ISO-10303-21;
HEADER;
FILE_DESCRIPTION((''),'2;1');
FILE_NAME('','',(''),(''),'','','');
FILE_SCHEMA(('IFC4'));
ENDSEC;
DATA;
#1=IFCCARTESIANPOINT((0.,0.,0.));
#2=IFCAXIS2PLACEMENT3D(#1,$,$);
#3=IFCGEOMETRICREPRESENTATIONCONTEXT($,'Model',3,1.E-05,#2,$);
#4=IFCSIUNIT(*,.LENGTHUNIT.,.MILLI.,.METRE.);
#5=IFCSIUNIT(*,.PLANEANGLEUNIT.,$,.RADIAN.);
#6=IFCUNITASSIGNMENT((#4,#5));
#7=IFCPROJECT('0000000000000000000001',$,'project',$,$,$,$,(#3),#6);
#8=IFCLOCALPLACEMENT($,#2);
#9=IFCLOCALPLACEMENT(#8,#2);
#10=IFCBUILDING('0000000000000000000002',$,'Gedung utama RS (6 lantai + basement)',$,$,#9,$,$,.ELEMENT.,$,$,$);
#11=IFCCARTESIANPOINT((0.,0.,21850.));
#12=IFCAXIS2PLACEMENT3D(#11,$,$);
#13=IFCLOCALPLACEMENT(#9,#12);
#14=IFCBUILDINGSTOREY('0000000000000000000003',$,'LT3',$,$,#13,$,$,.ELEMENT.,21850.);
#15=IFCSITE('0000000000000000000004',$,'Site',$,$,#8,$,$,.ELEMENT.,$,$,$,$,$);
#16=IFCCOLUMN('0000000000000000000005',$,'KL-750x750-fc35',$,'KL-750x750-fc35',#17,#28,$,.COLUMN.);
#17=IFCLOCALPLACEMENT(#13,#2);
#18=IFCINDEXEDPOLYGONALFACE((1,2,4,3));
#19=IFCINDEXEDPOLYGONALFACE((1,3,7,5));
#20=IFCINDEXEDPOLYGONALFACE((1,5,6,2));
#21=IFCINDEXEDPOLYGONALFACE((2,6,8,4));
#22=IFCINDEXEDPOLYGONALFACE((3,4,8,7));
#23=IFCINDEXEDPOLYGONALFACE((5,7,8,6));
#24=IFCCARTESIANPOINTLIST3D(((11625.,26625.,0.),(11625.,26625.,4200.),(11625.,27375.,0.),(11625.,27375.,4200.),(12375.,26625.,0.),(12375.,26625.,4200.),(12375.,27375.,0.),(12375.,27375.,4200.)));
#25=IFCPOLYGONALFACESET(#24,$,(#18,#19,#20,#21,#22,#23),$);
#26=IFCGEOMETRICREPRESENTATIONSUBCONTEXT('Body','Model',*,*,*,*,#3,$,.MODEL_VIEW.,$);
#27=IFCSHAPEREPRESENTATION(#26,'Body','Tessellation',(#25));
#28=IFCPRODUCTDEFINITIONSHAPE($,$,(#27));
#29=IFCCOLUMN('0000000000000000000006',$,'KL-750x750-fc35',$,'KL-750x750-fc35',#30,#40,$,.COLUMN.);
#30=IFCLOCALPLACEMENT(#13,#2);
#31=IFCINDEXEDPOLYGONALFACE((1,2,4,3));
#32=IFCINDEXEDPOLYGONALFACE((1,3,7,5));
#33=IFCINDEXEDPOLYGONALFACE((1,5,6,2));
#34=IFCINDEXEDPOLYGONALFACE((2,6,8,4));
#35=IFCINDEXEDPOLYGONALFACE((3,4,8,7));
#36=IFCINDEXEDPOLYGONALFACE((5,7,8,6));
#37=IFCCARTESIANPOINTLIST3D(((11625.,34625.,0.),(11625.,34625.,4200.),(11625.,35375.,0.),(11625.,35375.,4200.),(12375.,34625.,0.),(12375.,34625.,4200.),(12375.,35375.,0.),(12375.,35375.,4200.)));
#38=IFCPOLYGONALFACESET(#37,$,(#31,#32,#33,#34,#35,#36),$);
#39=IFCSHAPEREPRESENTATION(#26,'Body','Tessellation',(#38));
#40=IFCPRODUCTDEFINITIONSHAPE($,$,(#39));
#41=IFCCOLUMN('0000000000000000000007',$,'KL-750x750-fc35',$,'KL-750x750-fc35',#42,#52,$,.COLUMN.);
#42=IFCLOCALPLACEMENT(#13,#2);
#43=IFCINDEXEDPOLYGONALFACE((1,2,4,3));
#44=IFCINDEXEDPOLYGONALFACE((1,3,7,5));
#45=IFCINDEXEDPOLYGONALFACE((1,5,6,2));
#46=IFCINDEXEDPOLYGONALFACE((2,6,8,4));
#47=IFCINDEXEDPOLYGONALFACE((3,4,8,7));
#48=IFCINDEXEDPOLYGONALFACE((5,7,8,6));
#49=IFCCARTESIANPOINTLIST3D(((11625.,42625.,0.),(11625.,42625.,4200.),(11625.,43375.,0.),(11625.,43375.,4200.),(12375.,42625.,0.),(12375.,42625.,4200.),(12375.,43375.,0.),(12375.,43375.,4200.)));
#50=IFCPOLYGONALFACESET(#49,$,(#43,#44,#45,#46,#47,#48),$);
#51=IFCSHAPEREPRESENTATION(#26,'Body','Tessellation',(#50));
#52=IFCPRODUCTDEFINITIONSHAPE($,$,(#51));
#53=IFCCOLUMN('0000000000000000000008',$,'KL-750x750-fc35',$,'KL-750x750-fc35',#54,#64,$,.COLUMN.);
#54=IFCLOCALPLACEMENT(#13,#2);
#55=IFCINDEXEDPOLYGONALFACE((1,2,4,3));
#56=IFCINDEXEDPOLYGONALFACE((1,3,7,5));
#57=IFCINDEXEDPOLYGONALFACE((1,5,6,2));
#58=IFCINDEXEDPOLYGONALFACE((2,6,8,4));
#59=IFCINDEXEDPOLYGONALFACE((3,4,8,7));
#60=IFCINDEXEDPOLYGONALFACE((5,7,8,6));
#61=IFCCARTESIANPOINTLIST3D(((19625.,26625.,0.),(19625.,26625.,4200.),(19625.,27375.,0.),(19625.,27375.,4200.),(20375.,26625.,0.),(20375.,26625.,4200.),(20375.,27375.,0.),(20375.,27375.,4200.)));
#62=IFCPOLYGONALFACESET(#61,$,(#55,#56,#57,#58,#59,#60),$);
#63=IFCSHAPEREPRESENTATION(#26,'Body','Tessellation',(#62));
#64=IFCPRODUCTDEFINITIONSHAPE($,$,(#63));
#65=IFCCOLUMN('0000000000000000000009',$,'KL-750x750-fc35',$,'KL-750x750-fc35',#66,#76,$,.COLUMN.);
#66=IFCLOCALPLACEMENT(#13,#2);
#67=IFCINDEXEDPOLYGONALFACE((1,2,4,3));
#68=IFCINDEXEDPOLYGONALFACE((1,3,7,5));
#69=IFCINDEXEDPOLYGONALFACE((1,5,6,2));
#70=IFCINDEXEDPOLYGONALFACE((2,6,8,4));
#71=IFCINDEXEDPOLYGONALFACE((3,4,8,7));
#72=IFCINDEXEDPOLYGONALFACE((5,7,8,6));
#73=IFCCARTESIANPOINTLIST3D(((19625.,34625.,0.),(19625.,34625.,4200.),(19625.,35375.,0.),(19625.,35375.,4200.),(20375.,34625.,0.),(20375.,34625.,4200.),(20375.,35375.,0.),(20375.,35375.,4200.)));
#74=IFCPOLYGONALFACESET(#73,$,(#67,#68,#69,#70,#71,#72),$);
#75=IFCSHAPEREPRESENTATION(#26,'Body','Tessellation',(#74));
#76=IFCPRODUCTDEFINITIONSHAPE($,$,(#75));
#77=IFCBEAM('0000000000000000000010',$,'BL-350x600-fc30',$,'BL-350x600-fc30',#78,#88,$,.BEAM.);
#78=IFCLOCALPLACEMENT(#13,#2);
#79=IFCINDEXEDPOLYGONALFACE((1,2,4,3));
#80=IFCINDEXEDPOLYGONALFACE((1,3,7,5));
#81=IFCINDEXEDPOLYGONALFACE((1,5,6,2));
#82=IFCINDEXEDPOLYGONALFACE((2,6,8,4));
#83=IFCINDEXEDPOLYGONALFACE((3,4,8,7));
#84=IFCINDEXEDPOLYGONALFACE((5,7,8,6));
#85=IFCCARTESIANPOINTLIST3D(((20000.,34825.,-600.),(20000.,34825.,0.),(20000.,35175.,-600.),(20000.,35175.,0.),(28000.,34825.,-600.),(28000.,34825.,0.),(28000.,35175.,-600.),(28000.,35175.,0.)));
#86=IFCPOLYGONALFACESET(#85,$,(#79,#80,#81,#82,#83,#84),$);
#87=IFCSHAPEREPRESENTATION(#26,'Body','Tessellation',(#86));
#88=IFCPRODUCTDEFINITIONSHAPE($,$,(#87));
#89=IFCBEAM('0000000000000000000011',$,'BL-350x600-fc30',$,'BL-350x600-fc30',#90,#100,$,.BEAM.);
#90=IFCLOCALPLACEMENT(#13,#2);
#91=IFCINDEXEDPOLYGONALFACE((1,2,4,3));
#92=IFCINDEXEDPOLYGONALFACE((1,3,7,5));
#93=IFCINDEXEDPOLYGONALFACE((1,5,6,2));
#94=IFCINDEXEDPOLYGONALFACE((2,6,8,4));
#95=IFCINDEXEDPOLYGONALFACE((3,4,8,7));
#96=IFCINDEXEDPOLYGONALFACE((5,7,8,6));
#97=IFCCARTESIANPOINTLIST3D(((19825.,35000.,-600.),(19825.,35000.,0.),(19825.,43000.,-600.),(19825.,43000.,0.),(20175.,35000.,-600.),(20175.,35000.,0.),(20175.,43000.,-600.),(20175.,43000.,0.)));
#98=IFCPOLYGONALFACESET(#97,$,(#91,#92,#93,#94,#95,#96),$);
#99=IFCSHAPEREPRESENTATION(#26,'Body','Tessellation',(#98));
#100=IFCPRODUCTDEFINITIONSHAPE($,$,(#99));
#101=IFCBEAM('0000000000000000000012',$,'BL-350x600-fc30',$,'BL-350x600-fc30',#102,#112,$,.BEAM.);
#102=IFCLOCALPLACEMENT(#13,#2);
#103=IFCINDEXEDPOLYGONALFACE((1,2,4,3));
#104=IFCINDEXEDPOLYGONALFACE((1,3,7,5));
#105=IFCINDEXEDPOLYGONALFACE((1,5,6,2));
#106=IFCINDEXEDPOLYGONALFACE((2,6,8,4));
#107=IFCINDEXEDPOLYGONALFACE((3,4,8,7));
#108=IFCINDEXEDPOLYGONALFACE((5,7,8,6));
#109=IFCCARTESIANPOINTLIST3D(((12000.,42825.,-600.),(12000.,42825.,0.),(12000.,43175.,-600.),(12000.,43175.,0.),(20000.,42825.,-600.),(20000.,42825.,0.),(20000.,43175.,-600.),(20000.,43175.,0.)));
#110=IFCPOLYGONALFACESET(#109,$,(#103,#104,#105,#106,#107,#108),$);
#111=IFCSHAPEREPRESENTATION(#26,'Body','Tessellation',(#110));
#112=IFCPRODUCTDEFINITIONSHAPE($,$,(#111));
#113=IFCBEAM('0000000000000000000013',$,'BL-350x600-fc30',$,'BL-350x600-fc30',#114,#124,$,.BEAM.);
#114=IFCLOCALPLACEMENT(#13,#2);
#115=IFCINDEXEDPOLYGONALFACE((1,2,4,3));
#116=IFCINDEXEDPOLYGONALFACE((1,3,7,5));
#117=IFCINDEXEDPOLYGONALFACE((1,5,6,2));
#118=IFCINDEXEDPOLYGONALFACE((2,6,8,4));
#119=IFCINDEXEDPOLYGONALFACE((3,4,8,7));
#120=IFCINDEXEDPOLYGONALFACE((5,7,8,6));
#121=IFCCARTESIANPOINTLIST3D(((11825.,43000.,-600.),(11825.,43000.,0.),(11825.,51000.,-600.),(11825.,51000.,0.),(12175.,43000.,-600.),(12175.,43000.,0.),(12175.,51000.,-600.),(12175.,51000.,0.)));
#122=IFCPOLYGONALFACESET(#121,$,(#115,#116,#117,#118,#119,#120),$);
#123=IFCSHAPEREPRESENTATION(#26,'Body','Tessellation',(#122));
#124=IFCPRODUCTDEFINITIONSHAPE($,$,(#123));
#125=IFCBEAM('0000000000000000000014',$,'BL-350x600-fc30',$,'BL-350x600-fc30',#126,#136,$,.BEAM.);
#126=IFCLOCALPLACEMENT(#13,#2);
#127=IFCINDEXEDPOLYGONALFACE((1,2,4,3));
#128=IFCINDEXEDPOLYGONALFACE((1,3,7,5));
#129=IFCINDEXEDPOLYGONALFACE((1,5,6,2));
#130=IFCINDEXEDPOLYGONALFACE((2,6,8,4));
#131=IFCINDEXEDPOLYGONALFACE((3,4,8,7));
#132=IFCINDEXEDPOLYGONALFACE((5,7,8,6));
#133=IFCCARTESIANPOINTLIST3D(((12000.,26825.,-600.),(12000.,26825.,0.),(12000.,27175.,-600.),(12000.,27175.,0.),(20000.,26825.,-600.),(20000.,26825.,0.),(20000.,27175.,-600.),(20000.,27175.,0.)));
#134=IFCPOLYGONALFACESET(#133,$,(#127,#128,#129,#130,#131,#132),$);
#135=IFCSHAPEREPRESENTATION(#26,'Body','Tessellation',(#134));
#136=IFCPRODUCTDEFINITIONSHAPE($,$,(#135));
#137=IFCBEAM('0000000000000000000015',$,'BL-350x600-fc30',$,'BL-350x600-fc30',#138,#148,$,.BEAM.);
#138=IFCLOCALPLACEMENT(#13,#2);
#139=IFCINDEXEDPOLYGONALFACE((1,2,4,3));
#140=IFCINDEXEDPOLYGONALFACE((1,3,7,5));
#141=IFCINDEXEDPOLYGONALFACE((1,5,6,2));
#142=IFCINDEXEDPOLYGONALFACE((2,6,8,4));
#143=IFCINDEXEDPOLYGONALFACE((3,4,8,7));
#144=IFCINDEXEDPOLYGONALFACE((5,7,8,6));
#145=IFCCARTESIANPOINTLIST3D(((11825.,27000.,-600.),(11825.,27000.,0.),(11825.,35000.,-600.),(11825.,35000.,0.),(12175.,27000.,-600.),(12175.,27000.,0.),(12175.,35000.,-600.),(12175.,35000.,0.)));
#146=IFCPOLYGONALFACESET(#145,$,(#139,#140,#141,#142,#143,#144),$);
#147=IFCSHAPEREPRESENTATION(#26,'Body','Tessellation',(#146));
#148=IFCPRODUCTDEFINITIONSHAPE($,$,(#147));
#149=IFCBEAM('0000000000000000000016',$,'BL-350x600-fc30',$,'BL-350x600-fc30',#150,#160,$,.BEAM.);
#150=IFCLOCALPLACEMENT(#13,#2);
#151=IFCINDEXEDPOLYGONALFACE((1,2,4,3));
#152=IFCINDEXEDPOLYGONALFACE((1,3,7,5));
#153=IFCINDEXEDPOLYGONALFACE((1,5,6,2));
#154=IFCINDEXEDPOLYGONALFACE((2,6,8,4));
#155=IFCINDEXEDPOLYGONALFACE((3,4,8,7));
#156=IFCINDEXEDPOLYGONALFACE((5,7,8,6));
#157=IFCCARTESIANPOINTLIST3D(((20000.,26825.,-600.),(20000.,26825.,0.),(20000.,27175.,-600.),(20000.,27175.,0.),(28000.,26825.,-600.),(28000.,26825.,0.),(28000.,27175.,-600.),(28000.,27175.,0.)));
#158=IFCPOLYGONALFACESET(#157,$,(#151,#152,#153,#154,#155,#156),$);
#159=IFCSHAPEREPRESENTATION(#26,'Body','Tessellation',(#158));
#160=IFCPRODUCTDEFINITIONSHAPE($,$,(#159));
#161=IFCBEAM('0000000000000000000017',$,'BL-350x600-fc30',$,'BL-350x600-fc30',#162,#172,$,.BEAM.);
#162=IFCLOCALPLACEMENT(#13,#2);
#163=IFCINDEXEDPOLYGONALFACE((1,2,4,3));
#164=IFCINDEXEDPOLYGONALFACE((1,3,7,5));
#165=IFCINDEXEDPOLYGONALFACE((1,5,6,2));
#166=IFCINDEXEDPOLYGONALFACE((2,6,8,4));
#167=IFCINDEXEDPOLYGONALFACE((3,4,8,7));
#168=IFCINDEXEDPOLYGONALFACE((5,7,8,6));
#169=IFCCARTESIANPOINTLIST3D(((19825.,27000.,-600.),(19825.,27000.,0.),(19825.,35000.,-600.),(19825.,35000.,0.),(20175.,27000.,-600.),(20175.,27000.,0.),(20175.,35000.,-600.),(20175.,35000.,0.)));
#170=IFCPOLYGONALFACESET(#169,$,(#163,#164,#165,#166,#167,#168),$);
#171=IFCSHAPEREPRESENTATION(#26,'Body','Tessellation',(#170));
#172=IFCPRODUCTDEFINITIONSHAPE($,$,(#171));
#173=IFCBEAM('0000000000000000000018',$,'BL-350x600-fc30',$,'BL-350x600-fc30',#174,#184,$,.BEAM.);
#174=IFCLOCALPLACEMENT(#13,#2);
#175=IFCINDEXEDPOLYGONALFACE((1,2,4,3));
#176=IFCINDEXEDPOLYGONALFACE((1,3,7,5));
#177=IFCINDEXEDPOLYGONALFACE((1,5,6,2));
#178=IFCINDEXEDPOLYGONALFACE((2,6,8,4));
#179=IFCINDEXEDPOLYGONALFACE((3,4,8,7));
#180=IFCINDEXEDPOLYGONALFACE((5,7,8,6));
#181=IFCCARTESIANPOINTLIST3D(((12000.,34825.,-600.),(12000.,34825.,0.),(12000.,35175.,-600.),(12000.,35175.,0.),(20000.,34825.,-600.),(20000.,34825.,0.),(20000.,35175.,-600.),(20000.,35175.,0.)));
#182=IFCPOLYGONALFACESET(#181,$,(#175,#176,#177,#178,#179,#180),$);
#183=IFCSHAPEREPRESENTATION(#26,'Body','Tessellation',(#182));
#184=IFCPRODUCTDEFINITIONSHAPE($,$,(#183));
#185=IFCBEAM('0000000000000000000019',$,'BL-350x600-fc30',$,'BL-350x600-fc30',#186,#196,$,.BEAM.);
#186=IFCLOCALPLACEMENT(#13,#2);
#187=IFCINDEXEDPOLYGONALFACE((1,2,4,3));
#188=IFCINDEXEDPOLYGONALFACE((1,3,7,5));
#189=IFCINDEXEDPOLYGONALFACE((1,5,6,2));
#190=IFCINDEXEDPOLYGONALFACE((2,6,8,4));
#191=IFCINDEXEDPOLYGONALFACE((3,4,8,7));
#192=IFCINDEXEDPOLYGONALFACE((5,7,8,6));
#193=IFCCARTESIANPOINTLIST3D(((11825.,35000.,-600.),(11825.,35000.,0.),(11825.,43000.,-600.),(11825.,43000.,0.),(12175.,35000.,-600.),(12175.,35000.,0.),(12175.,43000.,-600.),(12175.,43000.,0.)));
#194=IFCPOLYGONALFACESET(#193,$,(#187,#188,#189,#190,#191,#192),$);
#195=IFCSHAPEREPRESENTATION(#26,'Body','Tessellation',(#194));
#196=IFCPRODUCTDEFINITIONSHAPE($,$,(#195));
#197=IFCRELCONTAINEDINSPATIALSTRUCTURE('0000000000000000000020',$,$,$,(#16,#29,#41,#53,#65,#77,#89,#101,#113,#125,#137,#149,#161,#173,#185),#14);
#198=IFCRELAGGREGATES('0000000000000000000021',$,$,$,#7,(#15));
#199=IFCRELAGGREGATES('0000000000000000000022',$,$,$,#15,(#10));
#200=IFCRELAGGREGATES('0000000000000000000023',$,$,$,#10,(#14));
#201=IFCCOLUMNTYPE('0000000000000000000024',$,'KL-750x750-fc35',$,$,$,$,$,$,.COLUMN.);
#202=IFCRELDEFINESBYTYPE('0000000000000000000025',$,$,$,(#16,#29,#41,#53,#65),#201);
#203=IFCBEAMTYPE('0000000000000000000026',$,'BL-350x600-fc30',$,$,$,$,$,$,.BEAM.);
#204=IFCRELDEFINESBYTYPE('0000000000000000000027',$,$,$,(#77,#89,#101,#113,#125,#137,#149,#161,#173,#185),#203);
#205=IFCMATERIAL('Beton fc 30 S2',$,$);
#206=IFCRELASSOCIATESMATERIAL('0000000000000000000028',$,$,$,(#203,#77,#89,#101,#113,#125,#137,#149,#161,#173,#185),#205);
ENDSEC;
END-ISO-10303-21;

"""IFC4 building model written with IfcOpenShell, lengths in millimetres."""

from ifc_helpers import new_model, si_unit, frame, origin, origin_2d, place, context, subcontext, project, spatial, rectangle, extrude, material, material_profile, profile_set, profile_usage, type_object, element, save


model = new_model("IFC4")

# Units and contexts
model_context = context("Model", 3, precision=1e-05, world=origin())
body_context = subcontext(model_context, "Body", "Model", "MODEL_VIEW")
ifc_project = project(units=[si_unit("LENGTHUNIT", "METRE", prefix="MILLI"), si_unit("PLANEANGLEUNIT", "RADIAN")], contexts=[model_context])

# Site, building, storey
site_placement = place(None, origin())
site = spatial("IfcSite", under=ifc_project, at=site_placement, Name="Site", CompositionType="ELEMENT")
building_placement = place(site_placement, origin())
building = spatial("IfcBuilding", under=site, at=building_placement, Name="Gedung utama RS (6 lantai + basement)", CompositionType="ELEMENT")
storey_placement = place(building_placement, frame((0.0, 0.0, 21850.0)))
storey = spatial("IfcBuildingStorey", under=building, at=storey_placement, Name="LT3", CompositionType="ELEMENT", Elevation=21850.0)

# Columns
ifc_material_profile_1 = material_profile(None, rectangle(XDim=750.0, YDim=750.0, at=origin_2d()), Name="KL-750x750-fc35")
ifc_profile_set_1 = profile_set([ifc_material_profile_1], Name="KL-750x750-fc35")
ifc_profile_usage_1 = profile_usage(ifc_profile_set_1, cardinal=5)
column_type = type_object("IfcColumnType", Name="KL-750x750-fc35", PredefinedType="COLUMN", material=ifc_profile_set_1)
for number, where, z_axis, x_axis, name in (
    (1, (12000.0, 27000.0, 0.0), (0.0, 0.0, 1.0), (1.0, 0.0, 0.0), "KL-750x750-fc35"),
    (2, (12000.0, 35000.0, 0.0), (0.0, 0.0, 1.0), (1.0, 0.0, 0.0), "KL-750x750-fc35"),
    (3, (12000.0, 43000.0, 0.0), (0.0, 0.0, 1.0), (1.0, 0.0, 0.0), "KL-750x750-fc35"),
    (4, (20000.0, 27000.0, 0.0), (0.0, 0.0, 1.0), (1.0, 0.0, 0.0), "KL-750x750-fc35"),
    (5, (20000.0, 35000.0, 0.0), (0.0, 0.0, 1.0), (1.0, 0.0, 0.0), "KL-750x750-fc35"),
):
    element("IfcColumn", number, at=place(storey_placement, frame(where, z_axis=z_axis, x_axis=x_axis)), inside=storey, type_object=column_type, material=ifc_profile_usage_1, Name=name, ObjectType="KL-750x750-fc35", PredefinedType="COLUMN", context=body_context, shape_type="SweptSolid", body=[
        extrude(rectangle(XDim=750.0, YDim=750.0, at=origin_2d()), origin(), (0.0, 0.0, 1.0), 4200.0),
    ])

# Beams
ifc_material_1 = material(Name="Beton fc 30 S2")
ifc_material_profile_2 = material_profile(ifc_material_1, rectangle(XDim=350.0, YDim=600.0, at=origin_2d()), Name="BL-350x600-fc30")
ifc_profile_set_2 = profile_set([ifc_material_profile_2], Name="BL-350x600-fc30")
ifc_profile_usage_2 = profile_usage(ifc_profile_set_2, cardinal=8)
beam_type = type_object("IfcBeamType", Name="BL-350x600-fc30", PredefinedType="BEAM", material=ifc_profile_set_2)
beam_1_placement = place(storey_placement, frame((20000.0, 35000.0, -300.0)))
element("IfcBeam", 6, at=beam_1_placement, inside=storey, type_object=beam_type, material=ifc_profile_usage_2, Name="BL-350x600-fc30", ObjectType="BL-350x600-fc30", PredefinedType="BEAM", context=body_context, shape_type="SweptSolid", body=[
    extrude(rectangle(XDim=350.0, YDim=600.0, at=origin_2d()), frame((0.0, 0.0, 0.0), z_axis=(1.0, 0.0, 0.0), x_axis=(0.0, 1.0, 0.0)), (0.0, 0.0, 1.0), 8000.0),
])
beam_2_placement = place(storey_placement, frame((20000.0, 35000.0, -300.0)))
element("IfcBeam", 7, at=beam_2_placement, inside=storey, type_object=beam_type, material=ifc_profile_usage_2, Name="BL-350x600-fc30", ObjectType="BL-350x600-fc30", PredefinedType="BEAM", context=body_context, shape_type="SweptSolid", body=[
    extrude(rectangle(XDim=350.0, YDim=600.0, at=origin_2d()), frame((0.0, 0.0, 0.0), z_axis=(0.0, 1.0, 0.0), x_axis=(-1.0, 0.0, 0.0)), (0.0, 0.0, 1.0), 8000.0),
])
beam_3_placement = place(storey_placement, frame((12000.0, 43000.0, -300.0)))
element("IfcBeam", 8, at=beam_3_placement, inside=storey, type_object=beam_type, material=ifc_profile_usage_2, Name="BL-350x600-fc30", ObjectType="BL-350x600-fc30", PredefinedType="BEAM", context=body_context, shape_type="SweptSolid", body=[
    extrude(rectangle(XDim=350.0, YDim=600.0, at=origin_2d()), frame((0.0, 0.0, 0.0), z_axis=(1.0, 0.0, 0.0), x_axis=(0.0, 1.0, 0.0)), (0.0, 0.0, 1.0), 8000.0),
])
beam_4_placement = place(storey_placement, frame((12000.0, 43000.0, -300.0)))
element("IfcBeam", 9, at=beam_4_placement, inside=storey, type_object=beam_type, material=ifc_profile_usage_2, Name="BL-350x600-fc30", ObjectType="BL-350x600-fc30", PredefinedType="BEAM", context=body_context, shape_type="SweptSolid", body=[
    extrude(rectangle(XDim=350.0, YDim=600.0, at=origin_2d()), frame((0.0, 0.0, 0.0), z_axis=(0.0, 1.0, 0.0), x_axis=(-1.0, 0.0, 0.0)), (0.0, 0.0, 1.0), 8000.0),
])
beam_5_placement = place(storey_placement, frame((12000.0, 27000.0, -300.0)))
element("IfcBeam", 10, at=beam_5_placement, inside=storey, type_object=beam_type, material=ifc_profile_usage_2, Name="BL-350x600-fc30", ObjectType="BL-350x600-fc30", PredefinedType="BEAM", context=body_context, shape_type="SweptSolid", body=[
    extrude(rectangle(XDim=350.0, YDim=600.0, at=origin_2d()), frame((0.0, 0.0, 0.0), z_axis=(1.0, 0.0, 0.0), x_axis=(0.0, 1.0, 0.0)), (0.0, 0.0, 1.0), 8000.0),
])
beam_6_placement = place(storey_placement, frame((12000.0, 27000.0, -300.0)))
element("IfcBeam", 11, at=beam_6_placement, inside=storey, type_object=beam_type, material=ifc_profile_usage_2, Name="BL-350x600-fc30", ObjectType="BL-350x600-fc30", PredefinedType="BEAM", context=body_context, shape_type="SweptSolid", body=[
    extrude(rectangle(XDim=350.0, YDim=600.0, at=origin_2d()), frame((0.0, 0.0, 0.0), z_axis=(0.0, 1.0, 0.0), x_axis=(-1.0, 0.0, 0.0)), (0.0, 0.0, 1.0), 8000.0),
])
beam_7_placement = place(storey_placement, frame((20000.0, 27000.0, -300.0)))
element("IfcBeam", 12, at=beam_7_placement, inside=storey, type_object=beam_type, material=ifc_profile_usage_2, Name="BL-350x600-fc30", ObjectType="BL-350x600-fc30", PredefinedType="BEAM", context=body_context, shape_type="SweptSolid", body=[
    extrude(rectangle(XDim=350.0, YDim=600.0, at=origin_2d()), frame((0.0, 0.0, 0.0), z_axis=(1.0, 0.0, 0.0), x_axis=(0.0, 1.0, 0.0)), (0.0, 0.0, 1.0), 8000.0),
])
beam_8_placement = place(storey_placement, frame((20000.0, 27000.0, -300.0)))
element("IfcBeam", 13, at=beam_8_placement, inside=storey, type_object=beam_type, material=ifc_profile_usage_2, Name="BL-350x600-fc30", ObjectType="BL-350x600-fc30", PredefinedType="BEAM", context=body_context, shape_type="SweptSolid", body=[
    extrude(rectangle(XDim=350.0, YDim=600.0, at=origin_2d()), frame((0.0, 0.0, 0.0), z_axis=(0.0, 1.0, 0.0), x_axis=(-1.0, 0.0, 0.0)), (0.0, 0.0, 1.0), 8000.0),
])
beam_9_placement = place(storey_placement, frame((12000.0, 35000.0, -300.0)))
element("IfcBeam", 14, at=beam_9_placement, inside=storey, type_object=beam_type, material=ifc_profile_usage_2, Name="BL-350x600-fc30", ObjectType="BL-350x600-fc30", PredefinedType="BEAM", context=body_context, shape_type="SweptSolid", body=[
    extrude(rectangle(XDim=350.0, YDim=600.0, at=origin_2d()), frame((0.0, 0.0, 0.0), z_axis=(1.0, 0.0, 0.0), x_axis=(0.0, 1.0, 0.0)), (0.0, 0.0, 1.0), 8000.0),
])
beam_10_placement = place(storey_placement, frame((12000.0, 35000.0, -300.0)))
element("IfcBeam", 15, at=beam_10_placement, inside=storey, type_object=beam_type, material=ifc_profile_usage_2, Name="BL-350x600-fc30", ObjectType="BL-350x600-fc30", PredefinedType="BEAM", context=body_context, shape_type="SweptSolid", body=[
    extrude(rectangle(XDim=350.0, YDim=600.0, at=origin_2d()), frame((0.0, 0.0, 0.0), z_axis=(0.0, 1.0, 0.0), x_axis=(-1.0, 0.0, 0.0)), (0.0, 0.0, 1.0), 8000.0),
])

save(model, "model.ifc")
